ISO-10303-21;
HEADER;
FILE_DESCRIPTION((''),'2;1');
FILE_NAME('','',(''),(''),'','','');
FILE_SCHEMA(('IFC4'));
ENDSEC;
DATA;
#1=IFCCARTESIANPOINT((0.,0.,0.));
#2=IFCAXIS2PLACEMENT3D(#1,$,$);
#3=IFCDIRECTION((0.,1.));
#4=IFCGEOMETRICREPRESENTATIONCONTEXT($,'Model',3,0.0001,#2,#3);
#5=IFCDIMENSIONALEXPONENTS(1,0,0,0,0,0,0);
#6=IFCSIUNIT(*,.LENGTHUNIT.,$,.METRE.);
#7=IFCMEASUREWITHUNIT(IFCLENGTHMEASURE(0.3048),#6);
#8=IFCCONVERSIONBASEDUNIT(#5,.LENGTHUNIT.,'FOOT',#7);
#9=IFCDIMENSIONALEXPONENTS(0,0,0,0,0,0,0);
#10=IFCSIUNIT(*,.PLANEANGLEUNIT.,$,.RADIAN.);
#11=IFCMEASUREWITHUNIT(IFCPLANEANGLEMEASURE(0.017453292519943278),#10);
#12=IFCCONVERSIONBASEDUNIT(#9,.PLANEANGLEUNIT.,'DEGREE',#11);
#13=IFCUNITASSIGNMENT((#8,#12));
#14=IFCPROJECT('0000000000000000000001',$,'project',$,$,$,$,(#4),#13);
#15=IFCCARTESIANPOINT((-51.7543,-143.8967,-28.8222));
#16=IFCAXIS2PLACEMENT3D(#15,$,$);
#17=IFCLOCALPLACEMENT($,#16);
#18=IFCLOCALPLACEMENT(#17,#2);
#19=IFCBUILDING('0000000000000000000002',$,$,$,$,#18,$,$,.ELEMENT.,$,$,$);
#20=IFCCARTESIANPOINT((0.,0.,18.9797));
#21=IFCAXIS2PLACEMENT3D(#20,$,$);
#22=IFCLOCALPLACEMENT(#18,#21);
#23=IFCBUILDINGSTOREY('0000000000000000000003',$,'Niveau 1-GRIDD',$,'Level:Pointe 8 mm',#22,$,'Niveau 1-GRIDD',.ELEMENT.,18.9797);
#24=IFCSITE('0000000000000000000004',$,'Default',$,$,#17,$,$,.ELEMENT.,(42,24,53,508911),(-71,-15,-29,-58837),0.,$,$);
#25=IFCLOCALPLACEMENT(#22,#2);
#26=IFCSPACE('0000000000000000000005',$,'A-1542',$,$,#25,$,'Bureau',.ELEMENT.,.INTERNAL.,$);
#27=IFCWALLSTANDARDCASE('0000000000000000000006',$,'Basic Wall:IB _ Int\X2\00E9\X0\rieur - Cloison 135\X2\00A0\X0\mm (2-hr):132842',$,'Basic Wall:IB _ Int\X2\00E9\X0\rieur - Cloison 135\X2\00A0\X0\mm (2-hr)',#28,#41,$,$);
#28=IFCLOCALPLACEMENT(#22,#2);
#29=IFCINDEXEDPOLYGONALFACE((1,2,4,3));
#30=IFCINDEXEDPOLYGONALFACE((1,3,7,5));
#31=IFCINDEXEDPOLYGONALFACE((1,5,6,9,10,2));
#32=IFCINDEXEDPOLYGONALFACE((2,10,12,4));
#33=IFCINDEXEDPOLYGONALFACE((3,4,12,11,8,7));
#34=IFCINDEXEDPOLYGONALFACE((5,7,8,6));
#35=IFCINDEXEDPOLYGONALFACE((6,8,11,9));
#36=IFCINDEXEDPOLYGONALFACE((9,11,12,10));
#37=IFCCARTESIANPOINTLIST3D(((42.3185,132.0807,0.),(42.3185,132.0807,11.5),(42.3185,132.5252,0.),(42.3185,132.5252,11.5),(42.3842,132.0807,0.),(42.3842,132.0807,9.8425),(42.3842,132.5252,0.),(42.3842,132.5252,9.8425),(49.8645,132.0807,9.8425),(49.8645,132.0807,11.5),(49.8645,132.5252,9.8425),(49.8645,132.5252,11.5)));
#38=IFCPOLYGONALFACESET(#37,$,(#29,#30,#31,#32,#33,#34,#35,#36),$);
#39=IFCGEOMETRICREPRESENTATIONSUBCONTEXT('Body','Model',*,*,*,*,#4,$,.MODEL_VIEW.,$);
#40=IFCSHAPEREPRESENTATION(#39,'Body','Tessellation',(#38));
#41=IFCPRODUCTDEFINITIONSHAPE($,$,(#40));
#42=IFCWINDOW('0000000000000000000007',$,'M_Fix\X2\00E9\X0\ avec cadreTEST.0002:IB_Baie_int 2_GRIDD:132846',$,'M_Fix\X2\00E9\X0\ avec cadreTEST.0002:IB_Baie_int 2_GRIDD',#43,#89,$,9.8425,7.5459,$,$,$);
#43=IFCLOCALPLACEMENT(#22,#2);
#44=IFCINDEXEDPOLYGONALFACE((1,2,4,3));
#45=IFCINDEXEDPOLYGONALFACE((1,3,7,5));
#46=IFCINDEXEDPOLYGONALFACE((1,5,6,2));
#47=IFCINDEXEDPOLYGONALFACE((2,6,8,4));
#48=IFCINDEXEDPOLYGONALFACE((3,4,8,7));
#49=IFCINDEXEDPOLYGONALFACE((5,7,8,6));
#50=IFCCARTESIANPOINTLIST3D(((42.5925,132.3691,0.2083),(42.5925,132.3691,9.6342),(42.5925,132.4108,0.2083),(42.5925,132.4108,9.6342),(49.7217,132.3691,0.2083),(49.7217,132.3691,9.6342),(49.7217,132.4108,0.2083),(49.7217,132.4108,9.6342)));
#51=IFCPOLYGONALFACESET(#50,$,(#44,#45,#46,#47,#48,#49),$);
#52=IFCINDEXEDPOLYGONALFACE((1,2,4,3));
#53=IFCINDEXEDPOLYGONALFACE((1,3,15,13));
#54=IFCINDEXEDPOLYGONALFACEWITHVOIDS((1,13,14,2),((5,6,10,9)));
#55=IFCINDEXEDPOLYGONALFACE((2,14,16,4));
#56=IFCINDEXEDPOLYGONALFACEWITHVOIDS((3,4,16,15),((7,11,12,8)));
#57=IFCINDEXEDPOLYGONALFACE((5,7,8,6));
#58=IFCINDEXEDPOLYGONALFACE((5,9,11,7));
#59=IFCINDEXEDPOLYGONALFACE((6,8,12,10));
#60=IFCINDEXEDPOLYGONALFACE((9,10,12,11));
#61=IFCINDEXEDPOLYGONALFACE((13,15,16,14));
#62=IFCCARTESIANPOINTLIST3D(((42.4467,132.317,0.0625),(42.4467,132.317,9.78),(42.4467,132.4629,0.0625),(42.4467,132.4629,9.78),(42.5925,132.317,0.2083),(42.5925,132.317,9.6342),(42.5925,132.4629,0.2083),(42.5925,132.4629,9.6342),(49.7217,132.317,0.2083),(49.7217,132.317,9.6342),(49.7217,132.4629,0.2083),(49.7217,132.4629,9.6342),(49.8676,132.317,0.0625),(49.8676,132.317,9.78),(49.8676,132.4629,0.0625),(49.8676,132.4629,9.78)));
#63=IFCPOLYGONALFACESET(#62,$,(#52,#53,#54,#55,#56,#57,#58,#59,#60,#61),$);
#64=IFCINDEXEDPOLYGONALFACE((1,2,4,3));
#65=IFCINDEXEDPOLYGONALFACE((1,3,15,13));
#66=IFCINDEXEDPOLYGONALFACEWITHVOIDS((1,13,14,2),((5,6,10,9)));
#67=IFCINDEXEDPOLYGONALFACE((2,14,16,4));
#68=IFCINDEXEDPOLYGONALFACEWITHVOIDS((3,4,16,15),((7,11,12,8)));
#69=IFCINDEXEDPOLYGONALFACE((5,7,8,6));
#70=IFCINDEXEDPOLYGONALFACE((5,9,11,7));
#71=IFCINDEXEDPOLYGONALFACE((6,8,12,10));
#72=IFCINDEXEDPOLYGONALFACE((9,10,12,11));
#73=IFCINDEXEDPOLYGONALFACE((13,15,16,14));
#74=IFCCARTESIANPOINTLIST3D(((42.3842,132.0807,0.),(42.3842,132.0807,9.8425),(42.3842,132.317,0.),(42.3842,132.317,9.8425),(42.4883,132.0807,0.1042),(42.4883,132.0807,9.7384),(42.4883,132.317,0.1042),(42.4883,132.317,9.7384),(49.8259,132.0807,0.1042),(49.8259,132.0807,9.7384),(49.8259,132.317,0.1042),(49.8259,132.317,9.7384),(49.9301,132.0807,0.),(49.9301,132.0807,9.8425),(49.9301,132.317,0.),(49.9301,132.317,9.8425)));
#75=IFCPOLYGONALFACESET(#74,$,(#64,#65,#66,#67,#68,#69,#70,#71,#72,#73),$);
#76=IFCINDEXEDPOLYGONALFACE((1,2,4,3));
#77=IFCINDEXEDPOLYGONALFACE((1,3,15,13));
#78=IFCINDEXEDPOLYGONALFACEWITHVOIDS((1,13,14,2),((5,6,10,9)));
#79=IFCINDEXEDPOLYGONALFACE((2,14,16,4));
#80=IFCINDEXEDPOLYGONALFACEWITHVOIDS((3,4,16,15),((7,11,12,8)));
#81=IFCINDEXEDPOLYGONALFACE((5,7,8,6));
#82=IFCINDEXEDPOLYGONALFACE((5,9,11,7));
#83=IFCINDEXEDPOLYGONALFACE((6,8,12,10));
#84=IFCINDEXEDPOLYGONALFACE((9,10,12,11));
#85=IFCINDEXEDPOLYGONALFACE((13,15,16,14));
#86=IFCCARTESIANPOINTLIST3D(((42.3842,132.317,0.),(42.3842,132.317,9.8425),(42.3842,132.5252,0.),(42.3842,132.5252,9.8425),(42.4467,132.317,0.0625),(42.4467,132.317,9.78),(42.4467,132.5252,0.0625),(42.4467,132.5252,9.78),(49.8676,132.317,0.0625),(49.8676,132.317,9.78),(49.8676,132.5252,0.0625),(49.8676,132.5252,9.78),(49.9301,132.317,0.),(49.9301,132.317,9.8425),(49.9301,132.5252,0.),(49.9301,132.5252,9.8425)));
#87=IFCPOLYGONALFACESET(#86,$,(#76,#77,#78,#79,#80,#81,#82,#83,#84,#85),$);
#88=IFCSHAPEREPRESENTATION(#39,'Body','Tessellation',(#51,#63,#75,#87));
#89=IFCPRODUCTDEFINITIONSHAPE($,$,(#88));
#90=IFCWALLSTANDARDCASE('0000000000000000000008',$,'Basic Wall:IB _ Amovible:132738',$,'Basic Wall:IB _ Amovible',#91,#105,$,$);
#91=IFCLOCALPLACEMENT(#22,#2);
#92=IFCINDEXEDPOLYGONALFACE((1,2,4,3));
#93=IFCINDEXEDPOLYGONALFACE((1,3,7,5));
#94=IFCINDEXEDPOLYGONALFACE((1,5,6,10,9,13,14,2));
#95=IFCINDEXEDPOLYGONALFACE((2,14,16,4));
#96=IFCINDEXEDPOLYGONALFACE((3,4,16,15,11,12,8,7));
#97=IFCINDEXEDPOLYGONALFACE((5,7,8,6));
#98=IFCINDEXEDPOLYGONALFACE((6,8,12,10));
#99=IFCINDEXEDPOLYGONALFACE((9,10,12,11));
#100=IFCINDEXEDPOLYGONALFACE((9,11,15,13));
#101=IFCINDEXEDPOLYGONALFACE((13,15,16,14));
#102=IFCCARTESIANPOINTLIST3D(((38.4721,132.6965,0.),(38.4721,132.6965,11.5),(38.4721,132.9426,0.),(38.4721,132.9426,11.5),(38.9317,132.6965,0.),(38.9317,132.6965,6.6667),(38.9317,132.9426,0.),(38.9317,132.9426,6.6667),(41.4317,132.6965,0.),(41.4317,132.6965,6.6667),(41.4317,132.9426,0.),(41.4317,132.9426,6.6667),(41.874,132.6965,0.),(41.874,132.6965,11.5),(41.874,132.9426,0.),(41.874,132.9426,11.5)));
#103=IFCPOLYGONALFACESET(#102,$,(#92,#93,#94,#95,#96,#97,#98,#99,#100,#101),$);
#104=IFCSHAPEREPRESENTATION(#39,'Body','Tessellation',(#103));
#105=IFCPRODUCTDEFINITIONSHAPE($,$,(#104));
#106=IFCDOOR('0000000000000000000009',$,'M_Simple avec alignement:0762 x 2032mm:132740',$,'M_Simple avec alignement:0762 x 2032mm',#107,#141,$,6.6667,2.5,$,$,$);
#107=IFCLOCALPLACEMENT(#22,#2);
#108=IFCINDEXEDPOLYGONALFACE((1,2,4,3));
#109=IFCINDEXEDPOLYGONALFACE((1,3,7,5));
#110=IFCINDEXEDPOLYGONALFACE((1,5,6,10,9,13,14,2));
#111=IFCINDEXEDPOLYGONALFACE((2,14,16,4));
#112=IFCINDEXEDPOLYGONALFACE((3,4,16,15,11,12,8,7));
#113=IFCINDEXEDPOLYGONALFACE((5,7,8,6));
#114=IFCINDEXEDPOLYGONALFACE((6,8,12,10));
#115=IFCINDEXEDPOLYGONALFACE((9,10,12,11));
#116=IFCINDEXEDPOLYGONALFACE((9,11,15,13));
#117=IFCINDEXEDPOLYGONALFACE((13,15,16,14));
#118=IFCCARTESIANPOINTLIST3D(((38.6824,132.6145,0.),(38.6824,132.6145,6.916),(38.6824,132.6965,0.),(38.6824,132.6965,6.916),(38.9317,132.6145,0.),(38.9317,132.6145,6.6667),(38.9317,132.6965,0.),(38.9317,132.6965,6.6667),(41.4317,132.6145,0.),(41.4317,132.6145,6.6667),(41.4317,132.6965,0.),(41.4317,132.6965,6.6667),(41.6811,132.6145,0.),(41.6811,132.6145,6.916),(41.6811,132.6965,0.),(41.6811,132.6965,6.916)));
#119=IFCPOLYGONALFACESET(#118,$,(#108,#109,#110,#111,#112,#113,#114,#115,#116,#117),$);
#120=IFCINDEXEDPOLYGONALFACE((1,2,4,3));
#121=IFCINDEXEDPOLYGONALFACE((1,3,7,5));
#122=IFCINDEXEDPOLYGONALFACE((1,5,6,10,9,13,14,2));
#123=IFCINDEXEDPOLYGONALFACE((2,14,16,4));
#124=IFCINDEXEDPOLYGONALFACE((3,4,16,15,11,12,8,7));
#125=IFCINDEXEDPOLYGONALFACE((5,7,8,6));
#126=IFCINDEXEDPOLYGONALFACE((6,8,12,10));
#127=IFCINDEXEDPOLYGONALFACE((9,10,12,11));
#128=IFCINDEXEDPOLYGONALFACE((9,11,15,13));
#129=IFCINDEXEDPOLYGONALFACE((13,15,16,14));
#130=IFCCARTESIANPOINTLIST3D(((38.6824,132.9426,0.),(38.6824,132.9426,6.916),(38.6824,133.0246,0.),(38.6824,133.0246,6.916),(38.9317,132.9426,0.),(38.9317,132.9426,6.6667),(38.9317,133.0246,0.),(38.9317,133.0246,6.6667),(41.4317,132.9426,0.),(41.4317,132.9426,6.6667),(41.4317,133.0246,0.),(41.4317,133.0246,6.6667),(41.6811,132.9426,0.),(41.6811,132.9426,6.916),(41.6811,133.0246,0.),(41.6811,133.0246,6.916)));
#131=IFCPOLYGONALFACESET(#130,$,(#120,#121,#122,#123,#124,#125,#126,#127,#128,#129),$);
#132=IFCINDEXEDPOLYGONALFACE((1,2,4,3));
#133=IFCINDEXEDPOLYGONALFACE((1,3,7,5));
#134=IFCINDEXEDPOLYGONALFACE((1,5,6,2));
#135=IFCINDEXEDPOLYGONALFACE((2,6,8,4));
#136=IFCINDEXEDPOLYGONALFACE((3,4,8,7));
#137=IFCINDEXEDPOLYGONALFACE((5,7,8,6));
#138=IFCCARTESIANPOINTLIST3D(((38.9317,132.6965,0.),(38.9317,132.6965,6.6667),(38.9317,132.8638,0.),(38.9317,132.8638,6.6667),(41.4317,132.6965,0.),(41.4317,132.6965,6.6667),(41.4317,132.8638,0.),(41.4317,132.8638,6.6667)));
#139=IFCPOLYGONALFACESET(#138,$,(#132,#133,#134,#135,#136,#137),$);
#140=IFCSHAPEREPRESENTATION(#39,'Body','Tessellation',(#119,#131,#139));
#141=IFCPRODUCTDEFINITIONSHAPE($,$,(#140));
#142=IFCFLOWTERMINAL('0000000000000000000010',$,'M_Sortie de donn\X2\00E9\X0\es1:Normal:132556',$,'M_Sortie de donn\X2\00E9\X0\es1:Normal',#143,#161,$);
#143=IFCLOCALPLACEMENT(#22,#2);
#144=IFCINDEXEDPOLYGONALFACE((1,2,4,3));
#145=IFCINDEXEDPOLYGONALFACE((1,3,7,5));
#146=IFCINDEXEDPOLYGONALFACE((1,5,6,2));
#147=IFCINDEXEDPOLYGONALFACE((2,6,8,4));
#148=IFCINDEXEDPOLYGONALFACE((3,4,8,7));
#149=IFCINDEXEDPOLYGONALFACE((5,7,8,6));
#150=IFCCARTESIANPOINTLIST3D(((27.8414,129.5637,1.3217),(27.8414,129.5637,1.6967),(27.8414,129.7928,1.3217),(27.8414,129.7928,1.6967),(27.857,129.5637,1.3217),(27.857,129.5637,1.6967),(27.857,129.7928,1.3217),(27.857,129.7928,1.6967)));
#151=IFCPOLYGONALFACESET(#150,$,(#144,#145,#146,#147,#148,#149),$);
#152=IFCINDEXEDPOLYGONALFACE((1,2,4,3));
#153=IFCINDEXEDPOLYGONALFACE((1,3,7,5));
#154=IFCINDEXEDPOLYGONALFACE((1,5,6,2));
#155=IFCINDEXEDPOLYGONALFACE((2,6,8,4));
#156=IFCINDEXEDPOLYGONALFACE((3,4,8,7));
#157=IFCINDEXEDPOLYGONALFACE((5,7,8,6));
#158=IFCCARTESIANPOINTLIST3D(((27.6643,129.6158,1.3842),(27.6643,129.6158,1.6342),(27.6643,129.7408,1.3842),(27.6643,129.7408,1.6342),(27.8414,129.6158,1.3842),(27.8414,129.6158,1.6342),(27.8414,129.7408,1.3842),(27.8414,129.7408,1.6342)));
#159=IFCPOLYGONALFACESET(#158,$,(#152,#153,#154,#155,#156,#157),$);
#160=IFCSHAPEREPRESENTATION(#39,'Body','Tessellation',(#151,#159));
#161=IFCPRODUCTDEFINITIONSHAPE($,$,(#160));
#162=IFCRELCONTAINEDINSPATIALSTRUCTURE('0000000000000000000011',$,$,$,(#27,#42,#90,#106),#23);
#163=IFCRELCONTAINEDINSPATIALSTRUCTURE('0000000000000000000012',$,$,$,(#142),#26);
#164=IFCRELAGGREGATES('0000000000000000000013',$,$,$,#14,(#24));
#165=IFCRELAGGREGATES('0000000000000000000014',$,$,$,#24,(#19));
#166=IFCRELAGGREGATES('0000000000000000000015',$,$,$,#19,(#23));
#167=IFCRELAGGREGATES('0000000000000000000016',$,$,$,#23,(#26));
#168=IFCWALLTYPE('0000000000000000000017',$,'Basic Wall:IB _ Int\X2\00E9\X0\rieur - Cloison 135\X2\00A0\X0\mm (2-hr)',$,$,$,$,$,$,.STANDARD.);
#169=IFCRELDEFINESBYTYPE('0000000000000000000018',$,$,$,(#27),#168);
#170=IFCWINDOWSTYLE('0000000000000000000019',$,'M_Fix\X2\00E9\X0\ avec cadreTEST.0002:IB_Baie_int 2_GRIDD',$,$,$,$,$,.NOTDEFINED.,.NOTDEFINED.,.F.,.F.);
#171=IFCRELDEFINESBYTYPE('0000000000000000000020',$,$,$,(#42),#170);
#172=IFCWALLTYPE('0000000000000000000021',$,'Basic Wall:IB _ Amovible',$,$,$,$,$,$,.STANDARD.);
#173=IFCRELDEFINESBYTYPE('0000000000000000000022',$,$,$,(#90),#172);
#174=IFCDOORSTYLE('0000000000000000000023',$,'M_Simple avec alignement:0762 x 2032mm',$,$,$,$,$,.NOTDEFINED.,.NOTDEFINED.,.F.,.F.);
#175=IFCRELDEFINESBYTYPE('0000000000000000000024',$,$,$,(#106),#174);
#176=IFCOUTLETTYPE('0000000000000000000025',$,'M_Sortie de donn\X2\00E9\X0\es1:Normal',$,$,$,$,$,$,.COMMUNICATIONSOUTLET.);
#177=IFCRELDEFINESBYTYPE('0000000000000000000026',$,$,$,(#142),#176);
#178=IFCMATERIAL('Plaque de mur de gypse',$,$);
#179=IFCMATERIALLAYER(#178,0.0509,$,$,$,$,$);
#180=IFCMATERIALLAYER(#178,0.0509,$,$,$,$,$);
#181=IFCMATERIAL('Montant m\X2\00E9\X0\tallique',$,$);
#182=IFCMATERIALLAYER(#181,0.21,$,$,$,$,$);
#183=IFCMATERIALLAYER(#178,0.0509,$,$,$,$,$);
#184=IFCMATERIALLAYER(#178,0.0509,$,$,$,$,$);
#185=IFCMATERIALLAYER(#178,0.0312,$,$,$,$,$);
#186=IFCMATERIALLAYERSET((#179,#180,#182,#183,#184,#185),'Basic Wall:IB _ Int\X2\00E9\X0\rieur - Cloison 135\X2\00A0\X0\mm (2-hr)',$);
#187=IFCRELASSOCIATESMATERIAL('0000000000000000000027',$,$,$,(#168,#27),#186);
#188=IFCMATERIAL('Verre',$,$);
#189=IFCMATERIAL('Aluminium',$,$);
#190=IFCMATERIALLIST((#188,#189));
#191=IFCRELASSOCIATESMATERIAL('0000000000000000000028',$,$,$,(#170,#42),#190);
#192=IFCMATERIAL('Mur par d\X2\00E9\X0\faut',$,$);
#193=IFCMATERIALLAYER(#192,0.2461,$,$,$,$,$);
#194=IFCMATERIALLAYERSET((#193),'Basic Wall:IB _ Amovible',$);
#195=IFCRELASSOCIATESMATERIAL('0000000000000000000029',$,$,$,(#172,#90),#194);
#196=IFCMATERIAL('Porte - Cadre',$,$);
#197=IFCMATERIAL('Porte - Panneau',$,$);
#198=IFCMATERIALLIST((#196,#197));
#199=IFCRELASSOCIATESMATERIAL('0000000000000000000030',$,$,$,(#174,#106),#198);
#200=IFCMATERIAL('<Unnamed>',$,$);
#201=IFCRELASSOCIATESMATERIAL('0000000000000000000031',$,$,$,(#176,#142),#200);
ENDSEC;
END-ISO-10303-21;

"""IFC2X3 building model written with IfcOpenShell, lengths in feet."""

from ifc_helpers import new_model, entity, si_unit, converted_unit, direction, frame, frame_2d, origin, origin_2d_with_axis, place, context, subcontext, project, spatial, polyline, rectangle, outline, extrude, source, transform, mapped, material, material_list, layer, layer_set, layer_usage, type_object, type_shapes, element, fill, save


model = new_model("IFC2X3")

# Units and contexts
model_context = context("Model", 3, precision=0.0001, world=origin(), true_north=direction((0.0, 1.0)))
body_context = subcontext(model_context, "Body", "Model", "MODEL_VIEW")
ifc_project = project(units=[converted_unit("LENGTHUNIT", "FOOT", entity("IfcLengthMeasure", 0.3048), si_unit("LENGTHUNIT", "METRE"), dimensions=[1, 0, 0, 0, 0, 0, 0]), converted_unit("PLANEANGLEUNIT", "DEGREE", entity("IfcPlaneAngleMeasure", 0.017453292519943278), si_unit("PLANEANGLEUNIT", "RADIAN"), dimensions=[0, 0, 0, 0, 0, 0, 0])], contexts=[model_context])

# Site, building, storey
site_placement = place(None, frame((-51.7543, -143.8967, -28.8222)))
site = spatial("IfcSite", under=ifc_project, at=site_placement, Name="Default", CompositionType="ELEMENT", RefLatitude=(42, 24, 53, 508911), RefLongitude=(-71, -15, -29, -58837), RefElevation=0.0)
building_placement = place(site_placement, origin())
building = spatial("IfcBuilding", under=site, at=building_placement, CompositionType="ELEMENT")
storey_placement = place(building_placement, frame((0.0, 0.0, 18.9797)))
storey = spatial("IfcBuildingStorey", under=building, at=storey_placement, Name="Niveau 1-GRIDD", ObjectType="Level:Pointe 8 mm", LongName="Niveau 1-GRIDD", CompositionType="ELEMENT", Elevation=18.9797)

# Wall, opening, window
ifc_material_1 = material(Name="Plaque de mur de gypse")
ifc_layer_1 = layer(ifc_material_1, 0.0509)
ifc_layer_2 = layer(ifc_material_1, 0.0509)
ifc_material_2 = material(Name="Montant métallique")
ifc_layer_3 = layer(ifc_material_2, 0.21)
ifc_layer_4 = layer(ifc_material_1, 0.0509)
ifc_layer_5 = layer(ifc_material_1, 0.0509)
ifc_layer_6 = layer(ifc_material_1, 0.0312)
ifc_layer_set_1 = layer_set([ifc_layer_1, ifc_layer_2, ifc_layer_3, ifc_layer_4, ifc_layer_5, ifc_layer_6], Name="Basic Wall:IB _ Intérieur - Cloison 135 mm (2-hr)")
ifc_layer_usage_1 = layer_usage(ifc_layer_set_1, "AXIS2", "NEGATIVE", 0.2223)
wall_type_1 = type_object("IfcWallType", Name="Basic Wall:IB _ Intérieur - Cloison 135 mm (2-hr)", PredefinedType="STANDARD", material=ifc_layer_set_1)
wall_1_placement = place(storey_placement, frame((42.3185, 132.3029, 0.0)))
wall_1 = element("IfcWallStandardCase", 1, at=wall_1_placement, inside=storey, type_object=wall_type_1, material=ifc_layer_usage_1, Name="Basic Wall:IB _ Intérieur - Cloison 135 mm (2-hr):132842", ObjectType="Basic Wall:IB _ Intérieur - Cloison 135 mm (2-hr)", context=body_context, shape_type="SweptSolid", body=[
    extrude(rectangle(XDim=7.5459, YDim=0.4446, at=frame_2d((3.773, 0.0), x_axis=(-1.0, 0.0))), origin(), (0.0, 0.0, 1.0), 11.5),
])
opening_1_placement = place(wall_1_placement, frame((0.0656, -0.2223, 0.0)))
opening_1 = element("IfcOpeningElement", 2, at=opening_1_placement, cuts=wall_1, ObjectType="Opening", context=body_context, shape_type="SweptSolid", body=[
    extrude(rectangle(XDim=9.8425, YDim=7.5459, at=frame_2d((4.9213, 3.773), x_axis=(-1.0, 0.0))), frame((0.0, 0.0, 0.0), z_axis=(0.0, 1.0, 0.0), x_axis=(0.0, 0.0, 1.0)), (0.0, 0.0, 1.0), 0.4446),
])
ifc_material_3 = material(Name="Verre")
ifc_material_4 = material(Name="Aluminium")
ifc_material_list_1 = material_list([ifc_material_3, ifc_material_4])
window_style = type_object("IfcWindowStyle", Name="M_Fixé avec cadreTEST.0002:IB_Baie_int 2_GRIDD", ConstructionType="NOTDEFINED", OperationType="NOTDEFINED", ParameterTakesPrecedence=False, Sizeable=False, material=ifc_material_list_1)
shared_shape_1 = source(origin(), body_context, "Body", "SweptSolid", [
    extrude(rectangle(XDim=0.0417, YDim=7.1293, at=frame_2d((0.0, 0.0), x_axis=(1.0, 0.0))), frame((3.773, 0.3093, 0.2083), z_axis=(0.0, 0.0, 1.0), x_axis=(0.0, 1.0, 0.0)), (0.0, 0.0, 1.0), 9.4259),
    extrude(outline(polyline([(-3.7105, -4.8588), (3.7105, -4.8588), (3.7105, 4.8588), (-3.7105, 4.8588), (-3.7105, -4.8588)]), holes=[polyline([(-3.5646, -4.7129), (-3.5646, 4.7129), (3.5646, 4.7129), (3.5646, -4.7129), (-3.5646, -4.7129)])]), frame((3.773, 0.2364, 4.9213), z_axis=(0.0, 1.0, 0.0), x_axis=(1.0, 0.0, 0.0)), (0.0, 0.0, 1.0), 0.1458),
    extrude(outline(polyline([(-3.773, -4.9213), (3.773, -4.9213), (3.773, 4.9213), (-3.773, 4.9213), (-3.773, -4.9213)]), holes=[polyline([(-3.6688, -4.8171), (-3.6688, 4.8171), (3.6688, 4.8171), (3.6688, -4.8171), (-3.6688, -4.8171)])]), frame((3.773, 0.0, 4.9213), z_axis=(0.0, 1.0, 0.0), x_axis=(1.0, 0.0, 0.0)), (0.0, 0.0, 1.0), 0.2364),
    extrude(outline(polyline([(-4.9213, -3.773), (4.9213, -3.773), (4.9213, 3.773), (-4.9213, 3.773), (-4.9213, -3.773)]), holes=[polyline([(-4.8588, -3.7105), (-4.8588, 3.7105), (4.8588, 3.7105), (4.8588, -3.7105), (-4.8588, -3.7105)])]), frame((3.773, 0.2364, 4.9213), z_axis=(0.0, 1.0, 0.0), x_axis=(0.0, 0.0, -1.0)), (0.0, 0.0, 1.0), 0.2082),
])
type_shapes(window_style, [shared_shape_1])
window_placement = place(opening_1_placement, origin())
window = element("IfcWindow", 3, at=window_placement, inside=storey, type_object=window_style, material=ifc_material_list_1, Name="M_Fixé avec cadreTEST.0002:IB_Baie_int 2_GRIDD:132846", ObjectType="M_Fixé avec cadreTEST.0002:IB_Baie_int 2_GRIDD", OverallHeight=9.8425, OverallWidth=7.5459, context=body_context, shape_type="MappedRepresentation", body=[
    mapped(shared_shape_1, transform((0.0, 0.0, 0.0), scale=1.0)),
])
fill(opening_1, window)

# Wall, openings, door
ifc_material_5 = material(Name="Mur par défaut")
ifc_layer_7 = layer(ifc_material_5, 0.2461)
ifc_layer_set_2 = layer_set([ifc_layer_7], Name="Basic Wall:IB _ Amovible")
ifc_layer_usage_2 = layer_usage(ifc_layer_set_2, "AXIS2", "NEGATIVE", 0.123)
wall_type_2 = type_object("IfcWallType", Name="Basic Wall:IB _ Amovible", PredefinedType="STANDARD", material=ifc_layer_set_2)
wall_2_placement = place(storey_placement, frame((38.4721, 132.8195, 0.0)))
wall_2 = element("IfcWallStandardCase", 4, at=wall_2_placement, inside=storey, type_object=wall_type_2, material=ifc_layer_usage_2, Name="Basic Wall:IB _ Amovible:132738", ObjectType="Basic Wall:IB _ Amovible", context=body_context, shape_type="SweptSolid", body=[
    extrude(rectangle(XDim=3.4019, YDim=0.2461, at=frame_2d((1.7009, 0.0), x_axis=(1.0, 0.0))), origin(), (0.0, 0.0, 1.0), 11.5),
])
opening_2_placement = place(wall_2_placement, origin())
element("IfcOpeningElement", 5, at=opening_2_placement, cuts=wall_2, ObjectType="Opening", context=body_context, shape_type="SweptSolid", body=[
    extrude(rectangle(XDim=4.9213, YDim=10.4331, at=frame_2d((0.0, 0.0), x_axis=(1.0, 0.0))), frame((-5.2165, -4.877, 4.4291), z_axis=(0.0, 1.0, 0.0), x_axis=(0.0, 0.0, -1.0)), (0.0, 0.0, 1.0), 10.0),
])
opening_3_placement = place(wall_2_placement, frame((2.9596, 0.123, 0.0)))
opening_3 = element("IfcOpeningElement", 6, at=opening_3_placement, cuts=wall_2, ObjectType="Opening", context=body_context, shape_type="SweptSolid", body=[
    extrude(rectangle(XDim=2.5, YDim=6.6667, at=frame_2d((3.3333, 1.25), x_axis=(0.0, 1.0))), frame((0.0, 0.0, 0.0), z_axis=(0.0, -1.0, 0.0), x_axis=(0.0, 0.0, 1.0)), (0.0, 0.0, 1.0), 0.2461),
])
ifc_material_6 = material(Name="Porte - Cadre")
ifc_material_7 = material(Name="Porte - Panneau")
ifc_material_list_2 = material_list([ifc_material_6, ifc_material_7])
door_style = type_object("IfcDoorStyle", Name="M_Simple avec alignement:0762 x 2032mm", ConstructionType="NOTDEFINED", OperationType="NOTDEFINED", ParameterTakesPrecedence=False, Sizeable=False, material=ifc_material_list_2)
shared_shape_2 = source(origin(), body_context, "Body", "SweptSolid", [
    extrude(outline(polyline([(-1.4993, -3.5203), (1.4993, -3.5203), (1.4993, 3.3957), (1.25, 3.3957), (1.25, -3.271), (-1.25, -3.271), (-1.25, 3.3957), (-1.4993, 3.3957), (-1.4993, -3.5203)])), frame((1.25, 0.2461, 3.3957), z_axis=(0.0, 1.0, 0.0), x_axis=(1.0, 0.0, 0.0)), (0.0, 0.0, 1.0), 0.082),
    extrude(outline(polyline([(-3.5203, -1.4993), (3.3957, -1.4993), (3.3957, -1.25), (-3.271, -1.25), (-3.271, 1.25), (3.3957, 1.25), (3.3957, 1.4993), (-3.5203, 1.4993), (-3.5203, -1.4993)])), frame((1.25, -0.082, 3.3957), z_axis=(0.0, 1.0, 0.0), x_axis=(0.0, 0.0, -1.0)), (0.0, 0.0, 1.0), 0.082),
    extrude(rectangle(XDim=0.1673, YDim=2.5, at=origin_2d_with_axis()), frame((1.25, 0.1624, 0.0), z_axis=(0.0, 0.0, 1.0), x_axis=(0.0, 1.0, 0.0)), (0.0, 0.0, 1.0), 6.6667),
])
type_shapes(door_style, [shared_shape_2])
door_placement = place(opening_3_placement, frame((0.0, 0.0, 0.0), z_axis=(0.0, 0.0, 1.0), x_axis=(-1.0, 0.0, 0.0)))
door = element("IfcDoor", 7, at=door_placement, inside=storey, type_object=door_style, material=ifc_material_list_2, Name="M_Simple avec alignement:0762 x 2032mm:132740", ObjectType="M_Simple avec alignement:0762 x 2032mm", OverallHeight=6.6667, OverallWidth=2.5, context=body_context, shape_type="MappedRepresentation", body=[
    mapped(shared_shape_2, transform((0.0, 0.0, 0.0), scale=1.0)),
])
fill(opening_3, door)

# Shared definitions
space_1_placement = place(storey_placement, origin())
space_1 = spatial("IfcSpace", under=storey, at=space_1_placement, Name="A-1542", LongName="Bureau", CompositionType="ELEMENT", InteriorOrExteriorSpace="INTERNAL")

# Flow terminal
ifc_material_8 = material(Name="<Unnamed>")
outlet_type = type_object("IfcOutletType", Name="M_Sortie de données1:Normal", PredefinedType="COMMUNICATIONSOUTLET", material=ifc_material_8)
shared_shape_3 = source(origin(), body_context, "Body", "SweptSolid", [
    extrude(rectangle(XDim=0.2292, YDim=0.375, at=frame_2d((0.0, 0.0), x_axis=(1.0, 0.0))), frame((0.0, 0.0, 0.0), z_axis=(0.0, 0.0, 1.0), x_axis=(-1.0, 0.0, 0.0)), (0.0, 0.0, 1.0), 0.0156),
    extrude(rectangle(XDim=0.125, YDim=0.25, at=frame_2d((0.0, 0.0), x_axis=(1.0, 0.0))), frame((0.0, 0.0, -0.1771), z_axis=(0.0, 0.0, 1.0), x_axis=(-1.0, 0.0, 0.0)), (0.0, 0.0, 1.0), 0.1771),
])
type_shapes(outlet_type, [shared_shape_3])
for number, where, z_axis, x_axis, name in (
    (8, (27.8414, 129.6783, 1.5092), (1.0, 0.0, 0.0), (0.0, 1.0, 0.0), "M_Sortie de données1:Normal:132556"),
):
    element("IfcFlowTerminal", number, at=place(space_1_placement, frame(where, z_axis=z_axis, x_axis=x_axis)), inside=space_1, type_object=outlet_type, material=ifc_material_8, Name=name, ObjectType="M_Sortie de données1:Normal", context=body_context, shape_type="MappedRepresentation", body=[
        mapped(shared_shape_3, transform((0.0, 0.0, 0.0), scale=1.0)),
    ])

save(model, "model.ifc")
